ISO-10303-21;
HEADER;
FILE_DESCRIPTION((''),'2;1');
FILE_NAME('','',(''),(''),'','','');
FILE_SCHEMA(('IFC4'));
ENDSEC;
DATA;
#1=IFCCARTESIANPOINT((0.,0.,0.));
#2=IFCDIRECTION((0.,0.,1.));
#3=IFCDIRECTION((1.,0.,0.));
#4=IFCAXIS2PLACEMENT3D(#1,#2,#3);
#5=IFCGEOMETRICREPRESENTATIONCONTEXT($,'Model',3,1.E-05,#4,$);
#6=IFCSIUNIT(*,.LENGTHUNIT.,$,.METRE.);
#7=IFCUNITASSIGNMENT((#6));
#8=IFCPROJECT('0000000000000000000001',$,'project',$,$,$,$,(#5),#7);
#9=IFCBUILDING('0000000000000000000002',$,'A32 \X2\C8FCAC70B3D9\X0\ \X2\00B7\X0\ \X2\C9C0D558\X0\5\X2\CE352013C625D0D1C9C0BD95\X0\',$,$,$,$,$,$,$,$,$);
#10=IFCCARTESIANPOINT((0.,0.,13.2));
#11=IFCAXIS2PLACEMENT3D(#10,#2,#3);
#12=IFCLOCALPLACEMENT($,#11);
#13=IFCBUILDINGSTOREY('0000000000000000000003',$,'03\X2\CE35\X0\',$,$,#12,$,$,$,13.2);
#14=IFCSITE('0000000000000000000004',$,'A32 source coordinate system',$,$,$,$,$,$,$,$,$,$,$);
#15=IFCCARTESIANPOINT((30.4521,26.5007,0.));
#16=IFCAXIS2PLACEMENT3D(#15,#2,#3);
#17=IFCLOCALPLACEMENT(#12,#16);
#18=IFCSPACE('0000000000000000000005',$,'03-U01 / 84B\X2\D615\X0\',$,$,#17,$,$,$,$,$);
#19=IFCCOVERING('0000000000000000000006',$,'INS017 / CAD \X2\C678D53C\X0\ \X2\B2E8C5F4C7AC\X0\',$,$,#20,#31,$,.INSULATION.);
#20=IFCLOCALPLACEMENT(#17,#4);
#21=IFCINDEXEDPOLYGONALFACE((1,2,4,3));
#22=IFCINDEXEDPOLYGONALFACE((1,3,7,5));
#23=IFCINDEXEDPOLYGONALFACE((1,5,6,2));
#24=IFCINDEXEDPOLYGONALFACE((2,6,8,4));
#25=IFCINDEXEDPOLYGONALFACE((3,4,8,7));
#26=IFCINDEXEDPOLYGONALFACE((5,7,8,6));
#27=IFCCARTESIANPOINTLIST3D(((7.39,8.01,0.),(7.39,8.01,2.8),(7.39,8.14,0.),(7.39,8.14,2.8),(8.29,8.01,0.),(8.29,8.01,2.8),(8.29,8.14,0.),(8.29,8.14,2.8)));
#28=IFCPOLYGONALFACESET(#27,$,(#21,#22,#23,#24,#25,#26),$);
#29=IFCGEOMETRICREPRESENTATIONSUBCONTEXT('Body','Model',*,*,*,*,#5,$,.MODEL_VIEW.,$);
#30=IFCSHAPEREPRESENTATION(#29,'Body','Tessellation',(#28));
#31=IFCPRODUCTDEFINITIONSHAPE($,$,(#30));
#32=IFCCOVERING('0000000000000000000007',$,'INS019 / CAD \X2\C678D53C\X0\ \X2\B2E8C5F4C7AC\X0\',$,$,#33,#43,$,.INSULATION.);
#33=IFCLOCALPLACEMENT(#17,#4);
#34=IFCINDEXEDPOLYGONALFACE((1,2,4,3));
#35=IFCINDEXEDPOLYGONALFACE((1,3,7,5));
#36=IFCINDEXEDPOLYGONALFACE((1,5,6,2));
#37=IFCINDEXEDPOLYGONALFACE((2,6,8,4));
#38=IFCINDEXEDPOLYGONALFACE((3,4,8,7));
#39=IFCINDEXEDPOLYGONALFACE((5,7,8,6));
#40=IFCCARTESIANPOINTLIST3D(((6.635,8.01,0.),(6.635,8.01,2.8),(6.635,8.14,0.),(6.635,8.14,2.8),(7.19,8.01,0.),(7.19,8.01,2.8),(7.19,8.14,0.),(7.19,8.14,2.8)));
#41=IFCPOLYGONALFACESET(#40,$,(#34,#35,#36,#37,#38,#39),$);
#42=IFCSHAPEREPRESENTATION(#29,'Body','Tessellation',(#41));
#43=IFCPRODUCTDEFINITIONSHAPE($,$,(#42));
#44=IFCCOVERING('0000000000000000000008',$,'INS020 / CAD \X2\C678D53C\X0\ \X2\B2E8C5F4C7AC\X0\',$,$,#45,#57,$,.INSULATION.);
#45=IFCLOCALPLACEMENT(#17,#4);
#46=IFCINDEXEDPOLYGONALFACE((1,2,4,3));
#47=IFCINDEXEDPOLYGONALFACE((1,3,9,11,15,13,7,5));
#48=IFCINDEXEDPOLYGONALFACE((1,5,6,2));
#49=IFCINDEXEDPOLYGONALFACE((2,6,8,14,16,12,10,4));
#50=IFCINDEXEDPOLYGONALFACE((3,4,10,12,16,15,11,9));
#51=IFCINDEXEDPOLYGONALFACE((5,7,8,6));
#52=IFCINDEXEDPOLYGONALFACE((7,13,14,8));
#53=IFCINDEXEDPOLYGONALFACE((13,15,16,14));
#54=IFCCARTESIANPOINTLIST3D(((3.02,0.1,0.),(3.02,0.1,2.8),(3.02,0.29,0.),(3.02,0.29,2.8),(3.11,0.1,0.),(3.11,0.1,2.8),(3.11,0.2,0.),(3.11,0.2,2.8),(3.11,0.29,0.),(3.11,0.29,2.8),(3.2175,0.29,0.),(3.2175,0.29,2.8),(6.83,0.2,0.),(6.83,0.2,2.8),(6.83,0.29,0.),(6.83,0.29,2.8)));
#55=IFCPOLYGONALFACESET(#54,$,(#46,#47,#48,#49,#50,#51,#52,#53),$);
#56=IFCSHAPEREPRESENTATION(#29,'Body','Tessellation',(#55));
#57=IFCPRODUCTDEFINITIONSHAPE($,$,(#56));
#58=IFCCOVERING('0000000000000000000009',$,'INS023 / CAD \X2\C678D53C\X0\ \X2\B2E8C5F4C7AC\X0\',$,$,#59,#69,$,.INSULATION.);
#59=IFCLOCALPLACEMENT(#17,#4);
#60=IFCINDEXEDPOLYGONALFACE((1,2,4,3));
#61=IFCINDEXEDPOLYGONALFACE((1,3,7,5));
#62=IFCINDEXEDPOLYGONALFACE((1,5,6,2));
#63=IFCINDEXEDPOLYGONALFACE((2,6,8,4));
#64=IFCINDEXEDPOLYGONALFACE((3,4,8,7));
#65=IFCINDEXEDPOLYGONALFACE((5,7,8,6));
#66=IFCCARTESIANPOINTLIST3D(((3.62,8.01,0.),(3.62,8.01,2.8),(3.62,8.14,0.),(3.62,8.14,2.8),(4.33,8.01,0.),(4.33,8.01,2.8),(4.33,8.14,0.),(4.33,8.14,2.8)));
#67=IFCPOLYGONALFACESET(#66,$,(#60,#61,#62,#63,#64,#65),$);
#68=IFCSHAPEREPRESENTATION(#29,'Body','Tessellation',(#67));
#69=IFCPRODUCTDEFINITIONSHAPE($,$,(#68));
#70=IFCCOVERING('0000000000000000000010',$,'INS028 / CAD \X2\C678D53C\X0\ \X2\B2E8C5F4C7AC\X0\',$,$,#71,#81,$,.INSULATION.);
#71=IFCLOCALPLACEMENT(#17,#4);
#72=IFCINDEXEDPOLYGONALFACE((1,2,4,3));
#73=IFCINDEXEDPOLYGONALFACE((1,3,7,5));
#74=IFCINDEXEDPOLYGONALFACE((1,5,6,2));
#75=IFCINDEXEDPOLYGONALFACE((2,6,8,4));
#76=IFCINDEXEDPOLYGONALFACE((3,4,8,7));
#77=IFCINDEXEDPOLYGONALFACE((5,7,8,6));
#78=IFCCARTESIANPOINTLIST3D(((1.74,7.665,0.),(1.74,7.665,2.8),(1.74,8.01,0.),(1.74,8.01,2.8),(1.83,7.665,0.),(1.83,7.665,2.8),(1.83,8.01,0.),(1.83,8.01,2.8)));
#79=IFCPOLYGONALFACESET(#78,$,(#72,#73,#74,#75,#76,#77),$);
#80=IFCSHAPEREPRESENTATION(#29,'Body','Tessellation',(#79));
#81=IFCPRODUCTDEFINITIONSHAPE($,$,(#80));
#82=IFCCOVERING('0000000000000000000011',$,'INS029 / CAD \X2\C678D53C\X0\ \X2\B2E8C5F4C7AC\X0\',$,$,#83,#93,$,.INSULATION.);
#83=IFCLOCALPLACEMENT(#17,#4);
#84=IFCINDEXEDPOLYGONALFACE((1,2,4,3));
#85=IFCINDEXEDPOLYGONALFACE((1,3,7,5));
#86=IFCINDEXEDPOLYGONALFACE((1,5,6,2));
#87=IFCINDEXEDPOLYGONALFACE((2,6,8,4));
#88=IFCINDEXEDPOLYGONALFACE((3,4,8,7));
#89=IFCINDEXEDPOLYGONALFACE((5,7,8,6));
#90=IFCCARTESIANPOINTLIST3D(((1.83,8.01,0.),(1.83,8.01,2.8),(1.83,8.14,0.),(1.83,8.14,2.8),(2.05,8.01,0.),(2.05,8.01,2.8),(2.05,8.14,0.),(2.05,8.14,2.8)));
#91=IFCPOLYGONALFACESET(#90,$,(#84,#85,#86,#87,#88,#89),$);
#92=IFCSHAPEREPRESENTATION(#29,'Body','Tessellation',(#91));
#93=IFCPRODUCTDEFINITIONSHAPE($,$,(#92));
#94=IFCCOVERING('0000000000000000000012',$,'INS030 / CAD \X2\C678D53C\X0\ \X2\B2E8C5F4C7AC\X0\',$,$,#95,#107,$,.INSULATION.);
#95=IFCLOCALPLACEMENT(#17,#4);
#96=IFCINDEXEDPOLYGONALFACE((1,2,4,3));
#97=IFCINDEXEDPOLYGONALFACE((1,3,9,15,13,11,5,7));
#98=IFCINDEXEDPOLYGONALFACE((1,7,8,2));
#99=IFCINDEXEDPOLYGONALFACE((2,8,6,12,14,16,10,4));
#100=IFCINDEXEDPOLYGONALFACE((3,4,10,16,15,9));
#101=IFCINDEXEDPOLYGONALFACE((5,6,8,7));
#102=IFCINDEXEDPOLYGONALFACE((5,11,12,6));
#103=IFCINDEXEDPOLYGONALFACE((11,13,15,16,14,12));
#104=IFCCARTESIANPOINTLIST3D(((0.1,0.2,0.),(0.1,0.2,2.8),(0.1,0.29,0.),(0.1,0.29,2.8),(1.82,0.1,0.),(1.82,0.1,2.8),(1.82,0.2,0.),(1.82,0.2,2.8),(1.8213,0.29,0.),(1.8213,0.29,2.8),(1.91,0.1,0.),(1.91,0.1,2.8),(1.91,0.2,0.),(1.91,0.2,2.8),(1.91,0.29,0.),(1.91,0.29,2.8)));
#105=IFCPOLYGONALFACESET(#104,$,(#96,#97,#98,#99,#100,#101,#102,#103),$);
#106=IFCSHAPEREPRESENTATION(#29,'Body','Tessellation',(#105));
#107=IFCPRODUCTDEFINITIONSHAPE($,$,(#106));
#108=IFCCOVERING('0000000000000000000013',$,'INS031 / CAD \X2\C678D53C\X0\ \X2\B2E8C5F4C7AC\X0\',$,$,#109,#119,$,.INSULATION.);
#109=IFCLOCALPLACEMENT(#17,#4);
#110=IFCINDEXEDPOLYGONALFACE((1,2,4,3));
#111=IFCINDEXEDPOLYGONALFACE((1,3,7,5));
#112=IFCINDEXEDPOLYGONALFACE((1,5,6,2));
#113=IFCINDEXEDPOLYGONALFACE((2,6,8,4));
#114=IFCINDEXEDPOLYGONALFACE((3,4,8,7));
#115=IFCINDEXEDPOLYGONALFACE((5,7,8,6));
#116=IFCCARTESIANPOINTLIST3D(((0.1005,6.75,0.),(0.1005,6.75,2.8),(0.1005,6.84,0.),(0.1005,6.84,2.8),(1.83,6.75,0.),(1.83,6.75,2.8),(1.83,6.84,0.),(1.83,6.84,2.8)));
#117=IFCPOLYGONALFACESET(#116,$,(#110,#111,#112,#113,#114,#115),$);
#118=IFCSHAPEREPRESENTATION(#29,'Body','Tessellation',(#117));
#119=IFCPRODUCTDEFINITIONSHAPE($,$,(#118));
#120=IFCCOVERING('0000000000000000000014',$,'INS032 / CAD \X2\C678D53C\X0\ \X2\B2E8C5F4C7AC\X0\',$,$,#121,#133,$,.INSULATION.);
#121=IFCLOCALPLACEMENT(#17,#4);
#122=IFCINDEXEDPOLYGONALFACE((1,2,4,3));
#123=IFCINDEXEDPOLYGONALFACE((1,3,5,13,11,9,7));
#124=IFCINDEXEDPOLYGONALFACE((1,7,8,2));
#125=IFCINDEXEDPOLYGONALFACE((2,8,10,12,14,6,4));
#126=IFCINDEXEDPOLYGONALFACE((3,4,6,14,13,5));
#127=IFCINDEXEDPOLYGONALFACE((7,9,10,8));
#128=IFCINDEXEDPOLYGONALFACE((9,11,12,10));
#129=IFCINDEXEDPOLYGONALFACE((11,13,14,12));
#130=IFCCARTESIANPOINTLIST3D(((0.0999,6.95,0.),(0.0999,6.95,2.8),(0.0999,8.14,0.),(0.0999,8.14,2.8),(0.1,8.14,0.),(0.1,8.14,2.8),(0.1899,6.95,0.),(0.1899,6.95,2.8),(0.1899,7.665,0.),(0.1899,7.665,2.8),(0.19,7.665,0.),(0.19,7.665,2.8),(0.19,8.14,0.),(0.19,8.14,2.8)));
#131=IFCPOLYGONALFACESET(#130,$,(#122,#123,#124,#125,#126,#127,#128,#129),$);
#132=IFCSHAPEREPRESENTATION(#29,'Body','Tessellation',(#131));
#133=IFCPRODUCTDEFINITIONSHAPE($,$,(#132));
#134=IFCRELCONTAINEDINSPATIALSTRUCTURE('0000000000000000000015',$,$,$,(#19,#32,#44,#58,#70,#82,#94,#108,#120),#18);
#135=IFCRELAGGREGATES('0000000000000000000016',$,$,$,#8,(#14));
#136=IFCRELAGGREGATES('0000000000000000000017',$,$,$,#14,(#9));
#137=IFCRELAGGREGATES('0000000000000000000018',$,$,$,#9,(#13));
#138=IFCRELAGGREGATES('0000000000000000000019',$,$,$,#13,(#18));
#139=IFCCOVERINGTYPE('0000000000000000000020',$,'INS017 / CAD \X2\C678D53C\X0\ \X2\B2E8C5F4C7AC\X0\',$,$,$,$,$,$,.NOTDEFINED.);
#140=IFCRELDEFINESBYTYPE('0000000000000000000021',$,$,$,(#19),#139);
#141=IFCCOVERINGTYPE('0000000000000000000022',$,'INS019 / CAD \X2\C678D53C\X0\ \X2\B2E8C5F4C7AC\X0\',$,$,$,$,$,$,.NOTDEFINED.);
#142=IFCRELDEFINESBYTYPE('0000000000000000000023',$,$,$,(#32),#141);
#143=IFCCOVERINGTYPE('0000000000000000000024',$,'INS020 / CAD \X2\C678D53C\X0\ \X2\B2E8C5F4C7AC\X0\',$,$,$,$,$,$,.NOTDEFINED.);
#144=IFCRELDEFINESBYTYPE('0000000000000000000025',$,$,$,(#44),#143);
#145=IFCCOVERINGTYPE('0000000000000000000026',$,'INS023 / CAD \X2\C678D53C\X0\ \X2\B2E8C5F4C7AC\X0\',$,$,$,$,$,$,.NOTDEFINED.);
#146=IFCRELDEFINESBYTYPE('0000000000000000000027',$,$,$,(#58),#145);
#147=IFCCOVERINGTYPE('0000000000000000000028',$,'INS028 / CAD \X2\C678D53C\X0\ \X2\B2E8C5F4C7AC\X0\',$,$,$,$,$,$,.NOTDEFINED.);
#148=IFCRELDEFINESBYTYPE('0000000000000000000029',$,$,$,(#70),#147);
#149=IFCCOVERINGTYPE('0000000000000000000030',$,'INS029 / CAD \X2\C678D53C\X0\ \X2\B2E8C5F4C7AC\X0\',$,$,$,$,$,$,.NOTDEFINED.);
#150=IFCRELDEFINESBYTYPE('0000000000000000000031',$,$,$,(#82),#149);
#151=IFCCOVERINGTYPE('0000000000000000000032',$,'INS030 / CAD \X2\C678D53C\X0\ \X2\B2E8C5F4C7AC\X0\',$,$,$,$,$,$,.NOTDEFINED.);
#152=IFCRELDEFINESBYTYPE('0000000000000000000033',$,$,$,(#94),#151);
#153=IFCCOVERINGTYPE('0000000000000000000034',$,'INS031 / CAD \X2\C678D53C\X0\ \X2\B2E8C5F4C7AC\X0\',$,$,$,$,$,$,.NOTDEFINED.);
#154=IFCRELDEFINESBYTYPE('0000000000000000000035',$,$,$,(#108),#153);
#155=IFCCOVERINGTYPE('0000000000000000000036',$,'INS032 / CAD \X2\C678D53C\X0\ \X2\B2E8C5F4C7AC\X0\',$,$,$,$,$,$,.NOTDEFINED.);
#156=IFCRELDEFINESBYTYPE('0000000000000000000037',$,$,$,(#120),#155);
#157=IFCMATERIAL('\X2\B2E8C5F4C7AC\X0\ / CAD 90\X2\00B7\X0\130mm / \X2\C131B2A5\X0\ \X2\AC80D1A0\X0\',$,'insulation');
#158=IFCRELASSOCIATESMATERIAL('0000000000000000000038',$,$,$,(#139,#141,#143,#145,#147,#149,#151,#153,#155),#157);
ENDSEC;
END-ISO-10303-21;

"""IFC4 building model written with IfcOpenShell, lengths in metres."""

from ifc_helpers import new_model, si_unit, frame, origin, origin_with_axes, place, context, subcontext, project, spatial, polyline, outline, extrude, source, transform, mapped, material, type_object, type_shapes, element, save


model = new_model("IFC4")

# Units and contexts
model_context = context("Model", 3, precision=1e-05, world=origin_with_axes())
body_context = subcontext(model_context, "Body", "Model", "MODEL_VIEW")
ifc_project = project(units=[si_unit("LENGTHUNIT", "METRE")], contexts=[model_context])

# Site, building, storey, space
storey_placement = place(None, frame((0.0, 0.0, 13.2), z_axis=(0.0, 0.0, 1.0), x_axis=(1.0, 0.0, 0.0)))
space_placement = place(storey_placement, frame((30.4521, 26.5007, 0.0), z_axis=(0.0, 0.0, 1.0), x_axis=(1.0, 0.0, 0.0)))
site = spatial("IfcSite", under=ifc_project, Name="A32 source coordinate system")
building = spatial("IfcBuilding", under=site, Name="A32 주거동 · 지하5층–옥탑지붕")
storey = spatial("IfcBuildingStorey", under=building, at=storey_placement, Name="03층", Elevation=13.2)
space = spatial("IfcSpace", under=storey, at=space_placement, Name="03-U01 / 84B형")

# Coverings
ifc_material = material(Name="단열재 / CAD 90·130mm / 성능 검토", Category="insulation")
covering_type_1 = type_object("IfcCoveringType", Name="INS017 / CAD 외피 단열재", PredefinedType="NOTDEFINED", material=ifc_material)
shared_shape_1 = source(origin(), body_context, "Body", "SweptSolid", [
    extrude(outline(polyline([(8.29, 8.01), (7.39, 8.01), (7.39, 8.14), (8.29, 8.14), (8.29, 8.01)])), origin(), (0.0, 0.0, 1.0), 2.8),
])
type_shapes(covering_type_1, [shared_shape_1])
covering_1_placement = place(space_placement, origin_with_axes())
element("IfcCovering", 1, at=covering_1_placement, inside=space, type_object=covering_type_1, Name="INS017 / CAD 외피 단열재", PredefinedType="INSULATION", context=body_context, shape_type="MappedRepresentation", body=[
    mapped(shared_shape_1, transform((0.0, 0.0, 0.0), scale=1.0)),
])
covering_type_2 = type_object("IfcCoveringType", Name="INS019 / CAD 외피 단열재", PredefinedType="NOTDEFINED", material=ifc_material)
shared_shape_2 = source(origin(), body_context, "Body", "SweptSolid", [
    extrude(outline(polyline([(6.635, 8.01), (6.635, 8.14), (7.19, 8.14), (7.19, 8.01), (6.635, 8.01)])), origin(), (0.0, 0.0, 1.0), 2.8),
])
type_shapes(covering_type_2, [shared_shape_2])
covering_2_placement = place(space_placement, origin_with_axes())
element("IfcCovering", 2, at=covering_2_placement, inside=space, type_object=covering_type_2, Name="INS019 / CAD 외피 단열재", PredefinedType="INSULATION", context=body_context, shape_type="MappedRepresentation", body=[
    mapped(shared_shape_2, transform((0.0, 0.0, 0.0), scale=1.0)),
])
covering_type_3 = type_object("IfcCoveringType", Name="INS020 / CAD 외피 단열재", PredefinedType="NOTDEFINED", material=ifc_material)
shared_shape_3 = source(origin(), body_context, "Body", "SweptSolid", [
    extrude(outline(polyline([(3.11, 0.2), (3.11, 0.1), (3.02, 0.1), (3.02, 0.29), (3.11, 0.29), (3.2175, 0.29), (6.83, 0.29), (6.83, 0.2), (3.11, 0.2)])), origin(), (0.0, 0.0, 1.0), 2.8),
])
type_shapes(covering_type_3, [shared_shape_3])
covering_3_placement = place(space_placement, origin_with_axes())
element("IfcCovering", 3, at=covering_3_placement, inside=space, type_object=covering_type_3, Name="INS020 / CAD 외피 단열재", PredefinedType="INSULATION", context=body_context, shape_type="MappedRepresentation", body=[
    mapped(shared_shape_3, transform((0.0, 0.0, 0.0), scale=1.0)),
])
covering_type_4 = type_object("IfcCoveringType", Name="INS023 / CAD 외피 단열재", PredefinedType="NOTDEFINED", material=ifc_material)
shared_shape_4 = source(origin(), body_context, "Body", "SweptSolid", [
    extrude(outline(polyline([(4.33, 8.01), (3.62, 8.01), (3.62, 8.14), (4.33, 8.14), (4.33, 8.01)])), origin(), (0.0, 0.0, 1.0), 2.8),
])
type_shapes(covering_type_4, [shared_shape_4])
covering_4_placement = place(space_placement, origin_with_axes())
element("IfcCovering", 4, at=covering_4_placement, inside=space, type_object=covering_type_4, Name="INS023 / CAD 외피 단열재", PredefinedType="INSULATION", context=body_context, shape_type="MappedRepresentation", body=[
    mapped(shared_shape_4, transform((0.0, 0.0, 0.0), scale=1.0)),
])
covering_type_5 = type_object("IfcCoveringType", Name="INS028 / CAD 외피 단열재", PredefinedType="NOTDEFINED", material=ifc_material)
shared_shape_5 = source(origin(), body_context, "Body", "SweptSolid", [
    extrude(outline(polyline([(1.74, 8.01), (1.83, 8.01), (1.83, 7.665), (1.74, 7.665), (1.74, 8.01)])), origin(), (0.0, 0.0, 1.0), 2.8),
])
type_shapes(covering_type_5, [shared_shape_5])
covering_5_placement = place(space_placement, origin_with_axes())
element("IfcCovering", 5, at=covering_5_placement, inside=space, type_object=covering_type_5, Name="INS028 / CAD 외피 단열재", PredefinedType="INSULATION", context=body_context, shape_type="MappedRepresentation", body=[
    mapped(shared_shape_5, transform((0.0, 0.0, 0.0), scale=1.0)),
])
covering_type_6 = type_object("IfcCoveringType", Name="INS029 / CAD 외피 단열재", PredefinedType="NOTDEFINED", material=ifc_material)
shared_shape_6 = source(origin(), body_context, "Body", "SweptSolid", [
    extrude(outline(polyline([(1.83, 8.01), (1.83, 8.14), (2.05, 8.14), (2.05, 8.01), (1.83, 8.01)])), origin(), (0.0, 0.0, 1.0), 2.8),
])
type_shapes(covering_type_6, [shared_shape_6])
covering_6_placement = place(space_placement, origin_with_axes())
element("IfcCovering", 6, at=covering_6_placement, inside=space, type_object=covering_type_6, Name="INS029 / CAD 외피 단열재", PredefinedType="INSULATION", context=body_context, shape_type="MappedRepresentation", body=[
    mapped(shared_shape_6, transform((0.0, 0.0, 0.0), scale=1.0)),
])
covering_type_7 = type_object("IfcCoveringType", Name="INS030 / CAD 외피 단열재", PredefinedType="NOTDEFINED", material=ifc_material)
shared_shape_7 = source(origin(), body_context, "Body", "SweptSolid", [
    extrude(outline(polyline([(1.91, 0.2), (1.91, 0.1), (1.82, 0.1), (1.82, 0.2), (0.1, 0.2), (0.1, 0.29), (1.8213, 0.29), (1.91, 0.29), (1.91, 0.2)])), origin(), (0.0, 0.0, 1.0), 2.8),
])
type_shapes(covering_type_7, [shared_shape_7])
covering_7_placement = place(space_placement, origin_with_axes())
element("IfcCovering", 7, at=covering_7_placement, inside=space, type_object=covering_type_7, Name="INS030 / CAD 외피 단열재", PredefinedType="INSULATION", context=body_context, shape_type="MappedRepresentation", body=[
    mapped(shared_shape_7, transform((0.0, 0.0, 0.0), scale=1.0)),
])
covering_type_8 = type_object("IfcCoveringType", Name="INS031 / CAD 외피 단열재", PredefinedType="NOTDEFINED", material=ifc_material)
shared_shape_8 = source(origin(), body_context, "Body", "SweptSolid", [
    extrude(outline(polyline([(1.83, 6.75), (0.1005, 6.75), (0.1005, 6.84), (1.83, 6.84), (1.83, 6.75)])), origin(), (0.0, 0.0, 1.0), 2.8),
])
type_shapes(covering_type_8, [shared_shape_8])
covering_8_placement = place(space_placement, origin_with_axes())
element("IfcCovering", 8, at=covering_8_placement, inside=space, type_object=covering_type_8, Name="INS031 / CAD 외피 단열재", PredefinedType="INSULATION", context=body_context, shape_type="MappedRepresentation", body=[
    mapped(shared_shape_8, transform((0.0, 0.0, 0.0), scale=1.0)),
])
covering_type_9 = type_object("IfcCoveringType", Name="INS032 / CAD 외피 단열재", PredefinedType="NOTDEFINED", material=ifc_material)
shared_shape_9 = source(origin(), body_context, "Body", "SweptSolid", [
    extrude(outline(polyline([(0.1899, 6.95), (0.0999, 6.95), (0.0999, 8.14), (0.1, 8.14), (0.19, 8.14), (0.19, 7.665), (0.1899, 7.665), (0.1899, 6.95)])), origin(), (0.0, 0.0, 1.0), 2.8),
])
type_shapes(covering_type_9, [shared_shape_9])
covering_9_placement = place(space_placement, origin_with_axes())
element("IfcCovering", 9, at=covering_9_placement, inside=space, type_object=covering_type_9, Name="INS032 / CAD 외피 단열재", PredefinedType="INSULATION", context=body_context, shape_type="MappedRepresentation", body=[
    mapped(shared_shape_9, transform((0.0, 0.0, 0.0), scale=1.0)),
])

save(model, "model.ifc")
